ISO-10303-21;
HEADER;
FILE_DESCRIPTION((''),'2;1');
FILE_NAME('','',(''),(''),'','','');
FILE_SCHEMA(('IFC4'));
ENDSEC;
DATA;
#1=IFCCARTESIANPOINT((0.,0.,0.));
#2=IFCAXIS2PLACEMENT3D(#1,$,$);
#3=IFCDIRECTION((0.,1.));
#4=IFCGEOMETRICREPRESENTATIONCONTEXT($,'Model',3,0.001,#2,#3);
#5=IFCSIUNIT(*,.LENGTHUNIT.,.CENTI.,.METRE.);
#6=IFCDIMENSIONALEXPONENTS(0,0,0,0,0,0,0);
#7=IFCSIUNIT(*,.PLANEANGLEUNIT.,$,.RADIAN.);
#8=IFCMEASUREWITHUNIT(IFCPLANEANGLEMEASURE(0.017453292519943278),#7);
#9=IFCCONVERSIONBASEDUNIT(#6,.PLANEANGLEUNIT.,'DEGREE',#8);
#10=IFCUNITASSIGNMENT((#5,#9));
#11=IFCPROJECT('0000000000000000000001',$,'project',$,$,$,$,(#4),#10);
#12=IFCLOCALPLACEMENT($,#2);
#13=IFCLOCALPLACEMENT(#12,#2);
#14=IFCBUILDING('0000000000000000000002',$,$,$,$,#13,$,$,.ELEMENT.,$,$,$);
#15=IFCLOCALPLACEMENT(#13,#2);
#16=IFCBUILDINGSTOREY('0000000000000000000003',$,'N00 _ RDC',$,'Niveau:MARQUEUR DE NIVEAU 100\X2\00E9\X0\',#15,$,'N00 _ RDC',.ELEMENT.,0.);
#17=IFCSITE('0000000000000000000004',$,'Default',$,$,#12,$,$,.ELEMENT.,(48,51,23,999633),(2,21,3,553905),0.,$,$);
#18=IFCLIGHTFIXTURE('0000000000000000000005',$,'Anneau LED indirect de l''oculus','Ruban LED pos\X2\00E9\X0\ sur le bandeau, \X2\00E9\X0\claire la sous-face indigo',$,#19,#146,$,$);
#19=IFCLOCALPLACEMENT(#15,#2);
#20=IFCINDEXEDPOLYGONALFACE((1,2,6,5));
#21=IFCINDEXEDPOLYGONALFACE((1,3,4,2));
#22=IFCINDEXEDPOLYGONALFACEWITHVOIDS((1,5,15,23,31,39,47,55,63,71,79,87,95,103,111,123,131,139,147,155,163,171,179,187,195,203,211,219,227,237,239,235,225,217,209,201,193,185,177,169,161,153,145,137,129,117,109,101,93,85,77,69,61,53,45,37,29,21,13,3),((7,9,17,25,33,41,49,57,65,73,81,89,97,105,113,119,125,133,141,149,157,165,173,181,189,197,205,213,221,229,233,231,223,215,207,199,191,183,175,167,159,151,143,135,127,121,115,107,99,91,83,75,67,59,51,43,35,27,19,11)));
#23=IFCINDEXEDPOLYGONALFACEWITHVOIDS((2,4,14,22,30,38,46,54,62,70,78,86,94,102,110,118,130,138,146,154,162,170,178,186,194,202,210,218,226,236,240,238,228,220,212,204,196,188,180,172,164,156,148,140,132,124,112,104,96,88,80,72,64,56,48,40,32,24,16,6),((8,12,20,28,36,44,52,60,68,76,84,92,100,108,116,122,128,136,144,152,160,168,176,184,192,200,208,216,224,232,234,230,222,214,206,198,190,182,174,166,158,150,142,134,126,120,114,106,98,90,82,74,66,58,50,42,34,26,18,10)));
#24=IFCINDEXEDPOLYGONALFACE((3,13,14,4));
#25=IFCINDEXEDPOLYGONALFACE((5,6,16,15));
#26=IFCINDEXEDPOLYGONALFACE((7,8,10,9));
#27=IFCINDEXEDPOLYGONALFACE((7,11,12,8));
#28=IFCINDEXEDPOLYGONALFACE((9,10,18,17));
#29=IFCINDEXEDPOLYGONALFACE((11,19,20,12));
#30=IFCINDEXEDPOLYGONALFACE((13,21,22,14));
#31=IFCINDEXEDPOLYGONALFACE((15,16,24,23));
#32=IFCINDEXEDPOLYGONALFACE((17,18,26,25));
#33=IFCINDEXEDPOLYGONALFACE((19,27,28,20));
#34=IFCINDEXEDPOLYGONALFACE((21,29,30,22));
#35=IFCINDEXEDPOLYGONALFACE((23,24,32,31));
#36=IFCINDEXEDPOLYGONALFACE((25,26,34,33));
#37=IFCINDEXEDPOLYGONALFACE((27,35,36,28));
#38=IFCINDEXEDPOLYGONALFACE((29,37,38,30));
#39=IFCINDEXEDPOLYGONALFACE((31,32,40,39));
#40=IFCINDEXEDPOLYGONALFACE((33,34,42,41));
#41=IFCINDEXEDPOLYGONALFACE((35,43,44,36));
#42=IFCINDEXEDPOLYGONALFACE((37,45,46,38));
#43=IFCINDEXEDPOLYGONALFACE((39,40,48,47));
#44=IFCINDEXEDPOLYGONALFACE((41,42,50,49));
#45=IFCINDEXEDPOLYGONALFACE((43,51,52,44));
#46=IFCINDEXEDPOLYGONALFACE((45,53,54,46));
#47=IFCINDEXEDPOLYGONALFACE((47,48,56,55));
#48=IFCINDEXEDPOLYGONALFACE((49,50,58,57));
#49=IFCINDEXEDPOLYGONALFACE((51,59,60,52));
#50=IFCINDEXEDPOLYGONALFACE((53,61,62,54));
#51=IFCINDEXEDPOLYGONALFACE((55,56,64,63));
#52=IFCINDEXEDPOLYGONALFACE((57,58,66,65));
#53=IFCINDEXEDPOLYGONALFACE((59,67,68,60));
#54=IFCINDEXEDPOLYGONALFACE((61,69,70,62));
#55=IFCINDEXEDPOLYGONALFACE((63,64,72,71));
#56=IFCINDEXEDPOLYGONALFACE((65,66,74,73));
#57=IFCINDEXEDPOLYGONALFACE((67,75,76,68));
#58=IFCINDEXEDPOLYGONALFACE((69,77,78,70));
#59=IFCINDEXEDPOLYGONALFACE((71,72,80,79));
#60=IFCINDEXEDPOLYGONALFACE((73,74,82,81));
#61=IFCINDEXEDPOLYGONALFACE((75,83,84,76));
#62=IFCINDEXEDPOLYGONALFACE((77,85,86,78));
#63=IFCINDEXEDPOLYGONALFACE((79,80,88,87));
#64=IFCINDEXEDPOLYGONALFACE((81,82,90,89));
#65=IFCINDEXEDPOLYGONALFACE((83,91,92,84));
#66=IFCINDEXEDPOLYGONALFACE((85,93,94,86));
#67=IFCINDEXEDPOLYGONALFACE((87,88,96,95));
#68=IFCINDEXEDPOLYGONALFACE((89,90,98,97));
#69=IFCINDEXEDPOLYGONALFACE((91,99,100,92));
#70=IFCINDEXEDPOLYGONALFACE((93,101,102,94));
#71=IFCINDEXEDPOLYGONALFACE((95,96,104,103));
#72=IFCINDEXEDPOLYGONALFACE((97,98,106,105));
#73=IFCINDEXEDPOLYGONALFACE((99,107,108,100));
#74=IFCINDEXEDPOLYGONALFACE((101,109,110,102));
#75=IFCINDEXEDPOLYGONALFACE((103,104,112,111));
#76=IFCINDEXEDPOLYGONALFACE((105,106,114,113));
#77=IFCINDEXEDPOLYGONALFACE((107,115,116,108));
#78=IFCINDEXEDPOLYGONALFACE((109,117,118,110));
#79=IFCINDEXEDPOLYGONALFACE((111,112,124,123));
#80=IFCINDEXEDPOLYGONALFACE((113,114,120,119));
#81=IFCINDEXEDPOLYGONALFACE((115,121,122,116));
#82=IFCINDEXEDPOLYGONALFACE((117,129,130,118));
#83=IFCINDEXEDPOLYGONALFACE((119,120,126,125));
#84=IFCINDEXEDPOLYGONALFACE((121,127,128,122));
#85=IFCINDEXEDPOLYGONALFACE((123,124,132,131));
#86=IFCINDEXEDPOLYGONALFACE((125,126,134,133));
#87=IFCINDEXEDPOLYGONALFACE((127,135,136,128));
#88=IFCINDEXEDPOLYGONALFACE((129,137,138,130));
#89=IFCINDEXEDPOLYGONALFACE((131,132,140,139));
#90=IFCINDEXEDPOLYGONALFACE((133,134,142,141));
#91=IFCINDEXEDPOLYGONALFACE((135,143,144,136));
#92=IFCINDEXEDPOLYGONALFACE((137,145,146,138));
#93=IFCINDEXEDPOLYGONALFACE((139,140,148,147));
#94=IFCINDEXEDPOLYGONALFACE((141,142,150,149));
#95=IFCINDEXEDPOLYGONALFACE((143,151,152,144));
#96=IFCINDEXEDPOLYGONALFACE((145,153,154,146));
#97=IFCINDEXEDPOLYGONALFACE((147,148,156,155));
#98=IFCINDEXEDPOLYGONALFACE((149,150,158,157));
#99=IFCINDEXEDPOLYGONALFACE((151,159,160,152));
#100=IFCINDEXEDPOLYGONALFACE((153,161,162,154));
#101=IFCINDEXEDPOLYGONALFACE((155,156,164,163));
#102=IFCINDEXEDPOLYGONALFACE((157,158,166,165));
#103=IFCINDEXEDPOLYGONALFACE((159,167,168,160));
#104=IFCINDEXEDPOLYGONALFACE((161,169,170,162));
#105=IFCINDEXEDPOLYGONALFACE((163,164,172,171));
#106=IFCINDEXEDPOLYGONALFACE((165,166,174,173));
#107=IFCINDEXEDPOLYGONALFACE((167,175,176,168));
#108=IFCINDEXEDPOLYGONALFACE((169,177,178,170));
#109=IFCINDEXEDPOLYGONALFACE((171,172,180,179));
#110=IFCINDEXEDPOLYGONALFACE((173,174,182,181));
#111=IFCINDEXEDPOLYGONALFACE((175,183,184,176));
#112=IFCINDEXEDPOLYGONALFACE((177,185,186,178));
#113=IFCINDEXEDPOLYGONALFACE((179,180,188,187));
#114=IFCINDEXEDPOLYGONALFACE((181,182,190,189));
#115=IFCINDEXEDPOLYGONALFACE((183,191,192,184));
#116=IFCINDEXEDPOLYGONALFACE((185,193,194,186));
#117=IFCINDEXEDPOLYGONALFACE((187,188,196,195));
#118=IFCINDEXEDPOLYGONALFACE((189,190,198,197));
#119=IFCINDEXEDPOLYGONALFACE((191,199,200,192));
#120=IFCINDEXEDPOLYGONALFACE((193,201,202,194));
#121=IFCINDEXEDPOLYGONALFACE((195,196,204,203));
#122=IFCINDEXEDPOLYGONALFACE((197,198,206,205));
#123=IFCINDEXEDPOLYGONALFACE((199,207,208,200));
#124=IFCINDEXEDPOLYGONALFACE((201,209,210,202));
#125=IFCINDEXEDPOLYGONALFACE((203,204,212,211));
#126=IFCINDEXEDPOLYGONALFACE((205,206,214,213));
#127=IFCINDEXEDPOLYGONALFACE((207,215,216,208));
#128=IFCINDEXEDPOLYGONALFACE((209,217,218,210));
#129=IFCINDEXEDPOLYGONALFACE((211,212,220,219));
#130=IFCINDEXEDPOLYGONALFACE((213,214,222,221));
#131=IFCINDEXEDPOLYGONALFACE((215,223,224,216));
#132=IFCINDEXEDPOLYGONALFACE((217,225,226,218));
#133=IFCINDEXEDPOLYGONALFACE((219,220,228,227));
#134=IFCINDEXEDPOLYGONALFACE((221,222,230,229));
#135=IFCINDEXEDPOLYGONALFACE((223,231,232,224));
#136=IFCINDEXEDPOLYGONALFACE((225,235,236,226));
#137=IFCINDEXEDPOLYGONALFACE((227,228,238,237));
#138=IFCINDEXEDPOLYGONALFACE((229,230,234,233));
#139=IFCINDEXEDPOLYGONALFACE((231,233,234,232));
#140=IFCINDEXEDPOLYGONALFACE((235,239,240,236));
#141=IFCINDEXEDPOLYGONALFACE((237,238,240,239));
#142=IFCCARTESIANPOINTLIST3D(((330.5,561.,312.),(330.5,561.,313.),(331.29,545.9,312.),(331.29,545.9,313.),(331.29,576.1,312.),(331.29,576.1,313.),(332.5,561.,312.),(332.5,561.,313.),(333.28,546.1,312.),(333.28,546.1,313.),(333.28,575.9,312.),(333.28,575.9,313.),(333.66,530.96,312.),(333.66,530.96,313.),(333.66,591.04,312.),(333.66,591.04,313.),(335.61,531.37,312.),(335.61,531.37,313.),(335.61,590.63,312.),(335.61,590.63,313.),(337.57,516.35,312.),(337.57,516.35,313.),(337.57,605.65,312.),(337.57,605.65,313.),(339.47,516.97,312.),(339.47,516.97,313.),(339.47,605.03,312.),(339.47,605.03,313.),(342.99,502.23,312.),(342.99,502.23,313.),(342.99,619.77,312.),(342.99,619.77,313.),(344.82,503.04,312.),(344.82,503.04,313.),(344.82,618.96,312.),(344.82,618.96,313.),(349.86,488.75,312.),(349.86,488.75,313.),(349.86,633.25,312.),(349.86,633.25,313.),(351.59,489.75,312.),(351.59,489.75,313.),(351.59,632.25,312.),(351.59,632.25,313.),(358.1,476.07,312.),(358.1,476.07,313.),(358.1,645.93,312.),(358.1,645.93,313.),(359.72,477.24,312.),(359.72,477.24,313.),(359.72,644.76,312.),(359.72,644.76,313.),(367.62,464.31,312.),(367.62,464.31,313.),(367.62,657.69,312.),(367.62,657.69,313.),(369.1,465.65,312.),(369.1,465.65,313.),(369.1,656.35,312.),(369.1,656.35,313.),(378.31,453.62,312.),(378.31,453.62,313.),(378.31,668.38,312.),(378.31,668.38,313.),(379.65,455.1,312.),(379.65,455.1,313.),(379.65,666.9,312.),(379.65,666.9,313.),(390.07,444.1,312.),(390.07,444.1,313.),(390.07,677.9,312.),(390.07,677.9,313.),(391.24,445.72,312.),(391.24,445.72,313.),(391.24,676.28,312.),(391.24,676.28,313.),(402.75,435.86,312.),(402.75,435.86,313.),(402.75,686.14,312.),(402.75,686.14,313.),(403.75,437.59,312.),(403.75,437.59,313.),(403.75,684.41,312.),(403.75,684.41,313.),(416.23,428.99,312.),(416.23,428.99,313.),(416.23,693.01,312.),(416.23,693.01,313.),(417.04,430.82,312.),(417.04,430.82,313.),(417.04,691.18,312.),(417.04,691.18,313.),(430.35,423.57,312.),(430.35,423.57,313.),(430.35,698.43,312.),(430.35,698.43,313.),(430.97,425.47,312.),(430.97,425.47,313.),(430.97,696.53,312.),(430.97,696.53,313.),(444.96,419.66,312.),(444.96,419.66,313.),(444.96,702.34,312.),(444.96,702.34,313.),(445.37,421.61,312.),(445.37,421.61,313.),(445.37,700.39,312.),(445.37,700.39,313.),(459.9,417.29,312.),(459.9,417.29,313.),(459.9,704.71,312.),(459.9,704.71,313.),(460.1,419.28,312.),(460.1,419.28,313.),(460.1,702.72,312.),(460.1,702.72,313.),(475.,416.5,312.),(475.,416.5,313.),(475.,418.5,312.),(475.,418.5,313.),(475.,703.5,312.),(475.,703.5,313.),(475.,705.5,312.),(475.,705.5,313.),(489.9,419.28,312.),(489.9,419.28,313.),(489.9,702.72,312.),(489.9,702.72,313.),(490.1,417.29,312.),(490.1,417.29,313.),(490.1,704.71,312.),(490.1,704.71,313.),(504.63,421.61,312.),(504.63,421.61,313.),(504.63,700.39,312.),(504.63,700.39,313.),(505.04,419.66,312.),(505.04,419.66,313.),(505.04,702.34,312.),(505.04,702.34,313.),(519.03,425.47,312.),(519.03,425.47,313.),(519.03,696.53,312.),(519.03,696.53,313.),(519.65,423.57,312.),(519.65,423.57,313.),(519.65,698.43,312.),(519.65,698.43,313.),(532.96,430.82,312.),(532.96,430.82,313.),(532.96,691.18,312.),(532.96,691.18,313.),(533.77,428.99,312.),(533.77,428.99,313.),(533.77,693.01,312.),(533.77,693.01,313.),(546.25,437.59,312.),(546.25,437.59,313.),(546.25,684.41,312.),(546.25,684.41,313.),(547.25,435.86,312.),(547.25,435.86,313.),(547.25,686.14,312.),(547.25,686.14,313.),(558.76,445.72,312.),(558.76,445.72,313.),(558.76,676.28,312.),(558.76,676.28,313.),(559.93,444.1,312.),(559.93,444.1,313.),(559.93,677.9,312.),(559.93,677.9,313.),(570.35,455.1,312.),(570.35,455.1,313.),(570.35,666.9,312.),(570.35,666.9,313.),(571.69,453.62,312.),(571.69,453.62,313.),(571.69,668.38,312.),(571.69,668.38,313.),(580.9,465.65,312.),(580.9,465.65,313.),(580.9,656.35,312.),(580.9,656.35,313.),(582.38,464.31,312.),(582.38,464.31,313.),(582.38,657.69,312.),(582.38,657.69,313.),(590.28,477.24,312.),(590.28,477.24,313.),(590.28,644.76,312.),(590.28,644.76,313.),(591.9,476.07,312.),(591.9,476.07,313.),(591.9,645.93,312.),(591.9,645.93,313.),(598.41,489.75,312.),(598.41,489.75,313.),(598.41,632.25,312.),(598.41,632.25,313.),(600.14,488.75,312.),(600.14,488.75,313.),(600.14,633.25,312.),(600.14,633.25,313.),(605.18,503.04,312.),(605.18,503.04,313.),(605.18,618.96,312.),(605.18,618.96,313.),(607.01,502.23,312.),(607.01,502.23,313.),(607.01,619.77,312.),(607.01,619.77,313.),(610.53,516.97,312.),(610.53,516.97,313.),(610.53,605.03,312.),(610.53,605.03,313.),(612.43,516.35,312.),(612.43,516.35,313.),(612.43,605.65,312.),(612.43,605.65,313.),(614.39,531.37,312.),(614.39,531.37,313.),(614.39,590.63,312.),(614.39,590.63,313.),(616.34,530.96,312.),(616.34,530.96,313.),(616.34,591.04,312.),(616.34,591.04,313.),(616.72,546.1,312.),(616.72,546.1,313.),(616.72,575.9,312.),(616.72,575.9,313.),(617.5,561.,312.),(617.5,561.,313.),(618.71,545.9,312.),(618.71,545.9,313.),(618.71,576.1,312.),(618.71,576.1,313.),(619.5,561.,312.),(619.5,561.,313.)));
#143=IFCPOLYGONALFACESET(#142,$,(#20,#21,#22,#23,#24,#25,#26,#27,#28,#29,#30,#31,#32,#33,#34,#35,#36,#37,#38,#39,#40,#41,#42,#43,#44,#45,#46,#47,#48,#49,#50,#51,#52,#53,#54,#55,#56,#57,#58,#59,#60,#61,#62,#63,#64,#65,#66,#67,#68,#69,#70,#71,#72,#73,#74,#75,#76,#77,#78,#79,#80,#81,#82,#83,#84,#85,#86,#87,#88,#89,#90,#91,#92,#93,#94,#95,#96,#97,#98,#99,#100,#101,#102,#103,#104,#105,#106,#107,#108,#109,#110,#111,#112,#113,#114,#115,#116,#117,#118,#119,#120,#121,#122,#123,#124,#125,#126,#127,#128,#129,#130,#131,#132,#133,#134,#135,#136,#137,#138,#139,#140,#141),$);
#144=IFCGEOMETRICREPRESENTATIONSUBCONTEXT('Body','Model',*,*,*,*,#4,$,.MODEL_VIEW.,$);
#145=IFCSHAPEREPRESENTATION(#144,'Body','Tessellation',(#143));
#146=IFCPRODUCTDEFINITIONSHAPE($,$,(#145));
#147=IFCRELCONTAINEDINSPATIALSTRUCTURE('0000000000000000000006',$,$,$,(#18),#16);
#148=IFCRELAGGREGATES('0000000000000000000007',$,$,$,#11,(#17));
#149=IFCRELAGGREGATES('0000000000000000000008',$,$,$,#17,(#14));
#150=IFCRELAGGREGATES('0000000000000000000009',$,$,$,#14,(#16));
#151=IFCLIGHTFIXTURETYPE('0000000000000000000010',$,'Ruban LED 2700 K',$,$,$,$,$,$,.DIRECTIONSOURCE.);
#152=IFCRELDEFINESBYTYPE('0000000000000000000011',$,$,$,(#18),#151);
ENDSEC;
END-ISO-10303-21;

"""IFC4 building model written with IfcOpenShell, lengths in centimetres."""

from ifc_helpers import new_model, entity, si_unit, converted_unit, direction, frame, frame_2d, origin, origin_with_axes, place, context, subcontext, project, spatial, hollow_circle, extrude, type_object, element, save


model = new_model("IFC4")

# Units and contexts
model_context = context("Model", 3, precision=0.001, world=origin(), true_north=direction((0.0, 1.0)))
body_context = subcontext(model_context, "Body", "Model", "MODEL_VIEW")
ifc_project = project(units=[si_unit("LENGTHUNIT", "METRE", prefix="CENTI"), converted_unit("PLANEANGLEUNIT", "DEGREE", entity("IfcPlaneAngleMeasure", 0.017453292519943278), si_unit("PLANEANGLEUNIT", "RADIAN"), dimensions=[0, 0, 0, 0, 0, 0, 0])], contexts=[model_context])

# Site, building, storey
site_placement = place(None, origin())
site = spatial("IfcSite", under=ifc_project, at=site_placement, Name="Default", CompositionType="ELEMENT", RefLatitude=(48, 51, 23, 999633), RefLongitude=(2, 21, 3, 553905), RefElevation=0.0)
building_placement = place(site_placement, origin())
building = spatial("IfcBuilding", under=site, at=building_placement, CompositionType="ELEMENT")
storey_placement = place(building_placement, origin())
storey = spatial("IfcBuildingStorey", under=building, at=storey_placement, Name="N00 _ RDC", ObjectType="Niveau:MARQUEUR DE NIVEAU 100é", LongName="N00 _ RDC", CompositionType="ELEMENT", Elevation=0.0)

# Light fixture
light_fixture_type_1 = type_object("IfcLightFixtureType", Name="Ruban LED 2700 K", PredefinedType="DIRECTIONSOURCE")
light_fixture_1_placement = place(storey_placement, origin_with_axes())
element("IfcLightFixture", 1, at=light_fixture_1_placement, inside=storey, type_object=light_fixture_type_1, Name="Anneau LED indirect de l'oculus", Description="Ruban LED posé sur le bandeau, éclaire la sous-face indigo", context=body_context, shape_type="SweptSolid", body=[
    extrude(hollow_circle(Radius=144.5, WallThickness=2.0, at=frame_2d((475.0, 561.0))), frame((0.0, 0.0, 312.0)), (0.0, 0.0, 1.0), 1.0),
])

save(model, "model.ifc")
